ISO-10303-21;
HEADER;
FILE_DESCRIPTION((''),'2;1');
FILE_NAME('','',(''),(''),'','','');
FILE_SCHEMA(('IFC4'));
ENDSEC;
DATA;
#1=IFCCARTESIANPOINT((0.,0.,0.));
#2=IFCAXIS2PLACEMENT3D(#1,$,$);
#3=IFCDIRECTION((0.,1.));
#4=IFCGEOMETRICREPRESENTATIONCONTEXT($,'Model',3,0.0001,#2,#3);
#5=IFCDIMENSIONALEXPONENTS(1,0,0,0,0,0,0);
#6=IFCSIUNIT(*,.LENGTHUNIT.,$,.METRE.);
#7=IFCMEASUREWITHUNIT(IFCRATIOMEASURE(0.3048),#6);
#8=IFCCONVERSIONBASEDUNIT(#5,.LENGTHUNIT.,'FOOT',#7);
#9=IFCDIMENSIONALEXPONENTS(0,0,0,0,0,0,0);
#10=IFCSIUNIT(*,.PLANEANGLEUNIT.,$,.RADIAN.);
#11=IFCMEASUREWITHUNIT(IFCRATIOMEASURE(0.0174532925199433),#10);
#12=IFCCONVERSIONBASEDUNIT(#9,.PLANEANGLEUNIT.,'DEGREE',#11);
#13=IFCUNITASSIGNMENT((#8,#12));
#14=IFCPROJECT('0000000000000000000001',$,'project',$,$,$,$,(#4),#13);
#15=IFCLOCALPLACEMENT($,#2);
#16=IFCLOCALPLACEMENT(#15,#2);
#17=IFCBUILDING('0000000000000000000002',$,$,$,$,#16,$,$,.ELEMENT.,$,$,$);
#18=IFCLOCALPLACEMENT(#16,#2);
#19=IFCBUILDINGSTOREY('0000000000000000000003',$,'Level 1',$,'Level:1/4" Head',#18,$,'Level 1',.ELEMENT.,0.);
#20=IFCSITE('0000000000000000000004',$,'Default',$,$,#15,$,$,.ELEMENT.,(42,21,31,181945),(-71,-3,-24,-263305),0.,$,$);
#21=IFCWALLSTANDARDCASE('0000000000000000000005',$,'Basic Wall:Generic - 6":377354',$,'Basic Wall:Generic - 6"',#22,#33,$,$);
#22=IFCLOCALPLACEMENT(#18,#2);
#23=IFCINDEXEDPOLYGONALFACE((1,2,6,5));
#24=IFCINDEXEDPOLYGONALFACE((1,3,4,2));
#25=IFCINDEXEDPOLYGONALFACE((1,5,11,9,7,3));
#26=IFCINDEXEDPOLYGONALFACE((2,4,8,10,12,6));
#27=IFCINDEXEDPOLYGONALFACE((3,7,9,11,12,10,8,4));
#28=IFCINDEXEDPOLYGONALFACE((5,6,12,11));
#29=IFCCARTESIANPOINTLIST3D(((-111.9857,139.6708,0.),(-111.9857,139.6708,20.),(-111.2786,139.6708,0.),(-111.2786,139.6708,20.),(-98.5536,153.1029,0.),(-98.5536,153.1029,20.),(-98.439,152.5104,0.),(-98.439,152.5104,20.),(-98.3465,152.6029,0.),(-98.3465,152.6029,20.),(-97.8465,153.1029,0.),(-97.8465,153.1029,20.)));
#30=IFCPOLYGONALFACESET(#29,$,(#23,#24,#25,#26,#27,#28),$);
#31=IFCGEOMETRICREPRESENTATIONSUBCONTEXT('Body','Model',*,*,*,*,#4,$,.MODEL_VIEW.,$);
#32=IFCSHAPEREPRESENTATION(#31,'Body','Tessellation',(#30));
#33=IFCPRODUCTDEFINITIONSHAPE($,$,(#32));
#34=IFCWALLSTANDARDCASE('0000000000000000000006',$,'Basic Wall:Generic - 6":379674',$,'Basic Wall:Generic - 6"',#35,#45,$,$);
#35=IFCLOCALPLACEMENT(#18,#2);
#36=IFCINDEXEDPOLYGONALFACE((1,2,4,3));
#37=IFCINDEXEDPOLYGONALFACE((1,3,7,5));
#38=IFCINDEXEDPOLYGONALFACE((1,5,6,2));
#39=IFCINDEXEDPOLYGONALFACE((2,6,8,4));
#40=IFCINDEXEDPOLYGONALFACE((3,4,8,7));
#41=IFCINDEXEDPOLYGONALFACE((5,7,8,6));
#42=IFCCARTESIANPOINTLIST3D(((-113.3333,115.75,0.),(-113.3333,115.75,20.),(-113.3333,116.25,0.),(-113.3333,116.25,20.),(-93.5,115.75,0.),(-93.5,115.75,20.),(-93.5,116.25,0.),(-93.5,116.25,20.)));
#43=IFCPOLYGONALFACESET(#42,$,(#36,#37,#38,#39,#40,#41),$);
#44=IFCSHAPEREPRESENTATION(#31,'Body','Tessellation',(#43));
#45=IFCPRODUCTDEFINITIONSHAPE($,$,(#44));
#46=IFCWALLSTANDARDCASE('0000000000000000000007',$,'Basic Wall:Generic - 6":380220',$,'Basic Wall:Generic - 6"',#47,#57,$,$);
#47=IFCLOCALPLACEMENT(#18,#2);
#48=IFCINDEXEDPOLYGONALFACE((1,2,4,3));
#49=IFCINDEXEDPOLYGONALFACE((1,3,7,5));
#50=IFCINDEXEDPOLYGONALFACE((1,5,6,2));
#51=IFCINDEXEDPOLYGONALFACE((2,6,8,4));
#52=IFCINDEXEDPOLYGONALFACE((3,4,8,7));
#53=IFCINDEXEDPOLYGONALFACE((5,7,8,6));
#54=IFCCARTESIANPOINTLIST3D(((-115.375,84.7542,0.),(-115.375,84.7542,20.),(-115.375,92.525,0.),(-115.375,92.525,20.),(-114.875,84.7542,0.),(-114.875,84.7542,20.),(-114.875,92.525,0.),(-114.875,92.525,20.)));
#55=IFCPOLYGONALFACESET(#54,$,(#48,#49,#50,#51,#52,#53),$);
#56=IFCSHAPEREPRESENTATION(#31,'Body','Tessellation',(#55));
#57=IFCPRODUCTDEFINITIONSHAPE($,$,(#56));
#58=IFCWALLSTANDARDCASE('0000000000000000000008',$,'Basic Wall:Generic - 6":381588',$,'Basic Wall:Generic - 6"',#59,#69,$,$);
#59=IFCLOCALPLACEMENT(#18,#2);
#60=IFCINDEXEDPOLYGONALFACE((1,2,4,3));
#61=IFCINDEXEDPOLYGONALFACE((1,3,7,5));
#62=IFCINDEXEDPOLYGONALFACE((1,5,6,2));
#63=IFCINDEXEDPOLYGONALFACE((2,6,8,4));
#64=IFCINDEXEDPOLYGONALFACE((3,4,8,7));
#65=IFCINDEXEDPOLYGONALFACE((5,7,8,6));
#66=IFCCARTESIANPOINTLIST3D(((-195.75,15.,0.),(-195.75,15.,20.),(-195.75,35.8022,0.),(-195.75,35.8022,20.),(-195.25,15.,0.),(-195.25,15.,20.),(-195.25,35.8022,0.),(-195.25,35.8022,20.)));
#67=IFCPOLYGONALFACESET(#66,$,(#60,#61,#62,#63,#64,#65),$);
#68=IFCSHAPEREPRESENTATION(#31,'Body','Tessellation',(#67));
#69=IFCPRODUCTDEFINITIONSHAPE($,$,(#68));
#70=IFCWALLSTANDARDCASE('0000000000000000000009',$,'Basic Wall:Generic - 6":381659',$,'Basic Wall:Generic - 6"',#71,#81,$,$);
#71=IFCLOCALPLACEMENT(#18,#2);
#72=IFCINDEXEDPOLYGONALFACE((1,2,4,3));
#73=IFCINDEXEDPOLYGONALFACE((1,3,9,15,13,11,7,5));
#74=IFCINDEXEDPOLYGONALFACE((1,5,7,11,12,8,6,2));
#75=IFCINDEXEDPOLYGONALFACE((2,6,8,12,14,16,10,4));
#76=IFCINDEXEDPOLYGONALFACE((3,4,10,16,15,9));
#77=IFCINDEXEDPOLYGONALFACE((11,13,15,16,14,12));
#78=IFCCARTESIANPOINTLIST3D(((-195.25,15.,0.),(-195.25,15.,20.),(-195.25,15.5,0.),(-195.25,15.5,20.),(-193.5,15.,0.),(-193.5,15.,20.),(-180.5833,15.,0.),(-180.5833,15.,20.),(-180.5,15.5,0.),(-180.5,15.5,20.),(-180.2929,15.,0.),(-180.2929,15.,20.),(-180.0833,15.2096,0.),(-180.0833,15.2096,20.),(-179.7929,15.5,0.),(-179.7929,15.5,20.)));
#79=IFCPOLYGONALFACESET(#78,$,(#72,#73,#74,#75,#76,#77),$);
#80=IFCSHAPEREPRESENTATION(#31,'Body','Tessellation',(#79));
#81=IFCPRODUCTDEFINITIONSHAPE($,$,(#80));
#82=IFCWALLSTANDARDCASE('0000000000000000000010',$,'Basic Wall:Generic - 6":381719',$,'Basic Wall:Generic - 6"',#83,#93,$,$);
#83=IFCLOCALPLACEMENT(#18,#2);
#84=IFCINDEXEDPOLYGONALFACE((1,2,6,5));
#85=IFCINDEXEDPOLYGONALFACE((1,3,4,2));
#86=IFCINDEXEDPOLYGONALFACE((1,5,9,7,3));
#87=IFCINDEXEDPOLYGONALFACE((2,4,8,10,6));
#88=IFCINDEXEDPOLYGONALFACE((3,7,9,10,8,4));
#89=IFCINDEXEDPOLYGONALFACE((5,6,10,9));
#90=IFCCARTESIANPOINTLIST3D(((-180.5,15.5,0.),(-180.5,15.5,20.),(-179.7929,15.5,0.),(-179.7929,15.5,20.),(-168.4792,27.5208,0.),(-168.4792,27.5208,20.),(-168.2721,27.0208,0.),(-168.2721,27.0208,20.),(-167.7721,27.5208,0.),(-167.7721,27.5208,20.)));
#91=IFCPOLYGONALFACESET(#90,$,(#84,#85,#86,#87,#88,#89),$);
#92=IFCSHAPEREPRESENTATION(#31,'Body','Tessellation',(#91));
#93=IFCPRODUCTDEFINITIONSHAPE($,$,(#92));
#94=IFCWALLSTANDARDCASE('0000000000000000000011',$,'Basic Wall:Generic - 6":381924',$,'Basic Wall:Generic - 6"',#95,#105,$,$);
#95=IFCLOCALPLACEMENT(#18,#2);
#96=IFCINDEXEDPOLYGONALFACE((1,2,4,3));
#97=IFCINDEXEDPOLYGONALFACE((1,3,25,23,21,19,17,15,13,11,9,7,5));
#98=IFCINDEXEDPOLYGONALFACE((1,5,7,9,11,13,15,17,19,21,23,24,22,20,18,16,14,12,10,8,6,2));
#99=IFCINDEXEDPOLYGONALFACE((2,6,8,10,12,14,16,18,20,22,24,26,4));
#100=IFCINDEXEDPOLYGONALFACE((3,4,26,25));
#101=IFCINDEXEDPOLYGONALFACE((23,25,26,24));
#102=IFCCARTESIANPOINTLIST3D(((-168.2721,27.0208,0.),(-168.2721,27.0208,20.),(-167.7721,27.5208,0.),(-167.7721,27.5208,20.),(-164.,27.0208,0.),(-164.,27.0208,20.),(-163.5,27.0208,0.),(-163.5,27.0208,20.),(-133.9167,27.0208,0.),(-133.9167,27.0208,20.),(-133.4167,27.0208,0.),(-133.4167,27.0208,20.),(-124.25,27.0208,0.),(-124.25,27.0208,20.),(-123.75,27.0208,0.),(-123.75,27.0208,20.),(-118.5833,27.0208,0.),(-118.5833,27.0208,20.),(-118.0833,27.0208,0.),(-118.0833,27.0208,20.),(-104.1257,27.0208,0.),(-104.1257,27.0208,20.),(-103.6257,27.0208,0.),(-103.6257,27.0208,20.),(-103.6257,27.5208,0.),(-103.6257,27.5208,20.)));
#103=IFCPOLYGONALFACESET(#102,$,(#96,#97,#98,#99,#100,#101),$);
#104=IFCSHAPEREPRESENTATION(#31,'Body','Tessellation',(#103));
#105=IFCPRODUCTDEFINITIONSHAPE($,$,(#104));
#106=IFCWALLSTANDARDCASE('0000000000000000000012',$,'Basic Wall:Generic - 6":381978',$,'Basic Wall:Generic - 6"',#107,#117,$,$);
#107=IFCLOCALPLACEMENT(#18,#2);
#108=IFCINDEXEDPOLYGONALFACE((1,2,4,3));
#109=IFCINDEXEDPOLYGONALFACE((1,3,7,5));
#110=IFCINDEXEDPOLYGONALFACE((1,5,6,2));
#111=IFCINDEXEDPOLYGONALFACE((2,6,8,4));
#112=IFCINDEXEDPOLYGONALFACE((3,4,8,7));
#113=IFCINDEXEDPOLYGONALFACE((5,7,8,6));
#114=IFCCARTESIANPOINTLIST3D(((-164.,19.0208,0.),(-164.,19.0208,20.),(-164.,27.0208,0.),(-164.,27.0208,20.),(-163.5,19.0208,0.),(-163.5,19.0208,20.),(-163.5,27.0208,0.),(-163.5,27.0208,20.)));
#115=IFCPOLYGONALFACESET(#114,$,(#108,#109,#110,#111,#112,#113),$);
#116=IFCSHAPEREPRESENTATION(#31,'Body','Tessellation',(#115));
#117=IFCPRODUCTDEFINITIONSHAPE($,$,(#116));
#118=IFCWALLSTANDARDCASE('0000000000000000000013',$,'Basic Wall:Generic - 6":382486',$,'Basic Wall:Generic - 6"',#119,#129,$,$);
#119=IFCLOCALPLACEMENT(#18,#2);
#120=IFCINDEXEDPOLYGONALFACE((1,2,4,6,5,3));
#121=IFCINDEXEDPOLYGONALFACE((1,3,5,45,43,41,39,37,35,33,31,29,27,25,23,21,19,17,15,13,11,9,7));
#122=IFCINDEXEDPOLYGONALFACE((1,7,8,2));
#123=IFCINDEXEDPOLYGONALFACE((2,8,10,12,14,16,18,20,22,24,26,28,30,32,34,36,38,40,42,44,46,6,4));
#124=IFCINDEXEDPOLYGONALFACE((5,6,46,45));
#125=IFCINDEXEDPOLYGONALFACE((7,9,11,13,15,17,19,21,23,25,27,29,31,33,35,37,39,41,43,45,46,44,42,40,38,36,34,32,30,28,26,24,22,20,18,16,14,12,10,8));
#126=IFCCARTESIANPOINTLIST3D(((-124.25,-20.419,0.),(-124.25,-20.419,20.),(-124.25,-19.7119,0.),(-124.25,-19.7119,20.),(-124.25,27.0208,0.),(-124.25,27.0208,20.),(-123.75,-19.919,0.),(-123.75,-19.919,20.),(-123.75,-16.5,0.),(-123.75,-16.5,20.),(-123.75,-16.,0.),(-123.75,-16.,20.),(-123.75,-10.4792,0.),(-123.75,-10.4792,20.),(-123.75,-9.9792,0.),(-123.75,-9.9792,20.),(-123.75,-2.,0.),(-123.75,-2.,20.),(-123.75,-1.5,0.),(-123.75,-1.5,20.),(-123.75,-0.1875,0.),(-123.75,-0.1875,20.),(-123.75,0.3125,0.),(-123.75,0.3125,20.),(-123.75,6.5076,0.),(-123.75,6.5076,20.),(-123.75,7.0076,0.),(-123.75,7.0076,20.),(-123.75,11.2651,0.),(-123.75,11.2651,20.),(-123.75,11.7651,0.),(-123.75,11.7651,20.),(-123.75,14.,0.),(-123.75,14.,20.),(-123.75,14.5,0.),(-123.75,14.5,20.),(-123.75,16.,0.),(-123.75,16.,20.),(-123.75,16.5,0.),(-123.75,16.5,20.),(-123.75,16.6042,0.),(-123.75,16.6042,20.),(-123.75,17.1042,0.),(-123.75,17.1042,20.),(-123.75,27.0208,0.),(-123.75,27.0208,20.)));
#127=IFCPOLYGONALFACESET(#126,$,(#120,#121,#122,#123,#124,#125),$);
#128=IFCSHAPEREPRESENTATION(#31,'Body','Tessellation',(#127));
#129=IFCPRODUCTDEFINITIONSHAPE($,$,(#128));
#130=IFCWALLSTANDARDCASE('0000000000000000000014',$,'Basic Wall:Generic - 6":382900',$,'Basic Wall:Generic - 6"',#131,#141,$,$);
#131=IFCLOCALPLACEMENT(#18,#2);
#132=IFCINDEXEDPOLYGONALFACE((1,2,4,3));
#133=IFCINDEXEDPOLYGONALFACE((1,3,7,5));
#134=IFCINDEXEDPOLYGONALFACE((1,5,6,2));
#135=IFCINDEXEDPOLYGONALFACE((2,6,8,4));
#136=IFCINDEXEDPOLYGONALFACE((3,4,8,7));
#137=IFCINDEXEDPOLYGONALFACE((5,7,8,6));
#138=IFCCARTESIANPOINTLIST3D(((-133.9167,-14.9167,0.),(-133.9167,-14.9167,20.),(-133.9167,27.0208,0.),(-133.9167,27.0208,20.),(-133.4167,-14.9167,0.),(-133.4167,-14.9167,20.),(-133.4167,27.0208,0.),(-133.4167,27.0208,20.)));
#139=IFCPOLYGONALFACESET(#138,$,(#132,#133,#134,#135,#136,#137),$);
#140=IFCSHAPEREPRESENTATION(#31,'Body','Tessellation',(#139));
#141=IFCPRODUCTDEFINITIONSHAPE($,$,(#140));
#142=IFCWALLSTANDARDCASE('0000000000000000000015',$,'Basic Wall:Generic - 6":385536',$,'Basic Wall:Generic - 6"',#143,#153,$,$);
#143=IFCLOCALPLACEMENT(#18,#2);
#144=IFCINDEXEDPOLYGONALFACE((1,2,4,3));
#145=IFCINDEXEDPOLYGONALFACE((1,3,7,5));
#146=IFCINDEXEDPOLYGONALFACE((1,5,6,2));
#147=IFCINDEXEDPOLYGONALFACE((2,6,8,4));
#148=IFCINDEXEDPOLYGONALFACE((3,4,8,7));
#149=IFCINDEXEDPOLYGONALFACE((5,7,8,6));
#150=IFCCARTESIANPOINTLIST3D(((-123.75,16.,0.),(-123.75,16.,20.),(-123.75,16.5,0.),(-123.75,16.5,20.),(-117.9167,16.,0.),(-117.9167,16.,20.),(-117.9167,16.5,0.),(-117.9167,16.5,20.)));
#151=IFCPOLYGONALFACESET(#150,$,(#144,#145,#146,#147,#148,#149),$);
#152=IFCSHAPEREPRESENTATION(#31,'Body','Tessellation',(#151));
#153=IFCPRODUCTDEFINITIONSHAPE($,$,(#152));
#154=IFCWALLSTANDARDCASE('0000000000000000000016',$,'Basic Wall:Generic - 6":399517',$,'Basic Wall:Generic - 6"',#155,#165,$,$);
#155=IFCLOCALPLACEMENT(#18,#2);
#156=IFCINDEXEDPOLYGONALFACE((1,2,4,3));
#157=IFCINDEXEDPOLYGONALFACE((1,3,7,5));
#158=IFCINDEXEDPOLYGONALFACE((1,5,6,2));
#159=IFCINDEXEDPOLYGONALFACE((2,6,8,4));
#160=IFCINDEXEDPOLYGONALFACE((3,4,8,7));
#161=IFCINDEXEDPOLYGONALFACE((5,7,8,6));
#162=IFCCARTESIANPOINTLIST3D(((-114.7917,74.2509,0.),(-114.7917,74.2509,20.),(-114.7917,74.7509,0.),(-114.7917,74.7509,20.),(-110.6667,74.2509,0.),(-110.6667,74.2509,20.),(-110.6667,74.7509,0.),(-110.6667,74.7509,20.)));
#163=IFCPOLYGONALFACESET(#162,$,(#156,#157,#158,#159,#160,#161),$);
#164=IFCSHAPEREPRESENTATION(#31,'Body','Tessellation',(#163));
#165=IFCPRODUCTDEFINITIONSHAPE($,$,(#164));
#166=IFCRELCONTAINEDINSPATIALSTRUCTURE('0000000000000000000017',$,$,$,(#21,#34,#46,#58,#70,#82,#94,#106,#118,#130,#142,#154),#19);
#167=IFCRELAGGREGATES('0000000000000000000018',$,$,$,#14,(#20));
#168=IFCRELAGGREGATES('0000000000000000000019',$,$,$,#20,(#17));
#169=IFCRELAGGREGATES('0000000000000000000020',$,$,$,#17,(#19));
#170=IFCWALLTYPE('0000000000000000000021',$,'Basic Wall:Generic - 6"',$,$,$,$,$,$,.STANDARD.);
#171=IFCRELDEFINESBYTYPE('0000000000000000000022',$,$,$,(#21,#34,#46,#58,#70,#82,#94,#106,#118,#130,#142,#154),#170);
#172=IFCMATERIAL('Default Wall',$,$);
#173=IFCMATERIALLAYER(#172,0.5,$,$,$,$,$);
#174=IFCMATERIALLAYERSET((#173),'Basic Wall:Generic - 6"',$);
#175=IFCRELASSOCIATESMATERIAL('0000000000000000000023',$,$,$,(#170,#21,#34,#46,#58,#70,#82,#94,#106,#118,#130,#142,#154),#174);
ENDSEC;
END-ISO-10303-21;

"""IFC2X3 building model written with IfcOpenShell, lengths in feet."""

from ifc_helpers import new_model, entity, si_unit, converted_unit, direction, frame, frame_2d, origin, place, context, subcontext, project, spatial, polyline, rectangle, outline, extrude, material, layer, layer_set, layer_usage, type_object, element, save


model = new_model("IFC2X3")

# Units and contexts
model_context = context("Model", 3, precision=0.0001, world=origin(), true_north=direction((0.0, 1.0)))
body_context = subcontext(model_context, "Body", "Model", "MODEL_VIEW")
ifc_project = project(units=[converted_unit("LENGTHUNIT", "FOOT", entity("IfcRatioMeasure", 0.3048), si_unit("LENGTHUNIT", "METRE"), dimensions=[1, 0, 0, 0, 0, 0, 0]), converted_unit("PLANEANGLEUNIT", "DEGREE", entity("IfcRatioMeasure", 0.0174532925199433), si_unit("PLANEANGLEUNIT", "RADIAN"), dimensions=[0, 0, 0, 0, 0, 0, 0])], contexts=[model_context])

# Site, building, storey
site_placement = place(None, origin())
site = spatial("IfcSite", under=ifc_project, at=site_placement, Name="Default", CompositionType="ELEMENT", RefLatitude=(42, 21, 31, 181945), RefLongitude=(-71, -3, -24, -263305), RefElevation=0.0)
building_placement = place(site_placement, origin())
building = spatial("IfcBuilding", under=site, at=building_placement, CompositionType="ELEMENT")
storey_placement = place(building_placement, origin())
storey = spatial("IfcBuildingStorey", under=building, at=storey_placement, Name="Level 1", ObjectType="Level:1/4\" Head", LongName="Level 1", CompositionType="ELEMENT", Elevation=0.0)

# Walls
ifc_material = material(Name="Default Wall")
ifc_layer_1 = layer(ifc_material, 0.5)
ifc_layer_set_1 = layer_set([ifc_layer_1], Name="Basic Wall:Generic - 6\"")
wall_type_1 = type_object("IfcWallType", Name="Basic Wall:Generic - 6\"", PredefinedType="STANDARD", material=ifc_layer_set_1)
ifc_layer_usage_1 = layer_usage(ifc_layer_set_1, "AXIS2", "NEGATIVE", 0.25)
wall_1_placement = place(storey_placement, frame((-111.8089, 139.4941, 0.0), z_axis=(0.0, 0.0, 1.0), x_axis=(0.707107, 0.707107, 0.0)))
element("IfcWallStandardCase", 1, at=wall_1_placement, inside=storey, type_object=wall_type_1, material=ifc_layer_usage_1, Name="Basic Wall:Generic - 6\":377354", ObjectType="Basic Wall:Generic - 6\"", context=body_context, shape_type="SweptSolid", body=[
    extrude(outline(polyline([(19.4959, -0.25), (18.9959, 0.25), (0.0, 0.25), (0.5, -0.25), (18.6579, -0.25), (18.7888, -0.25), (19.4959, -0.25)])), origin(), (0.0, 0.0, 1.0), 20.0),
])
ifc_layer_usage_2 = layer_usage(ifc_layer_set_1, "AXIS2", "NEGATIVE", 0.25)
wall_2_placement = place(storey_placement, frame((-113.3333, 116.0, 0.0)))
element("IfcWallStandardCase", 2, at=wall_2_placement, inside=storey, type_object=wall_type_1, material=ifc_layer_usage_2, Name="Basic Wall:Generic - 6\":379674", ObjectType="Basic Wall:Generic - 6\"", context=body_context, shape_type="SweptSolid", body=[
    extrude(rectangle(XDim=19.8333, YDim=0.5, at=frame_2d((9.9167, 0.0), x_axis=(-1.0, 0.0))), origin(), (0.0, 0.0, 1.0), 20.0),
])
ifc_layer_usage_3 = layer_usage(ifc_layer_set_1, "AXIS2", "NEGATIVE", 0.25)
wall_3_placement = place(storey_placement, frame((-115.125, 84.7542, 0.0), z_axis=(0.0, 0.0, 1.0), x_axis=(0.0, 1.0, 0.0)))
element("IfcWallStandardCase", 3, at=wall_3_placement, inside=storey, type_object=wall_type_1, material=ifc_layer_usage_3, Name="Basic Wall:Generic - 6\":380220", ObjectType="Basic Wall:Generic - 6\"", context=body_context, shape_type="SweptSolid", body=[
    extrude(rectangle(XDim=7.7708, YDim=0.5, at=frame_2d((3.8854, 0.0), x_axis=(-1.0, 0.0))), origin(), (0.0, 0.0, 1.0), 20.0),
])
ifc_layer_usage_4 = layer_usage(ifc_layer_set_1, "AXIS2", "NEGATIVE", 0.25)
wall_4_placement = place(storey_placement, frame((-195.5, 35.8022, 0.0), z_axis=(0.0, 0.0, 1.0), x_axis=(0.0, -1.0, 0.0)))
element("IfcWallStandardCase", 4, at=wall_4_placement, inside=storey, type_object=wall_type_1, material=ifc_layer_usage_4, Name="Basic Wall:Generic - 6\":381588", ObjectType="Basic Wall:Generic - 6\"", context=body_context, shape_type="SweptSolid", body=[
    extrude(rectangle(XDim=20.8022, YDim=0.5, at=frame_2d((10.4011, 0.0), x_axis=(-1.0, 0.0))), origin(), (0.0, 0.0, 1.0), 20.0),
])
ifc_layer_usage_5 = layer_usage(ifc_layer_set_1, "AXIS2", "NEGATIVE", 0.25)
wall_5_placement = place(storey_placement, frame((-195.25, 15.25, 0.0)))
element("IfcWallStandardCase", 5, at=wall_5_placement, inside=storey, type_object=wall_type_1, material=ifc_layer_usage_5, Name="Basic Wall:Generic - 6\":381659", ObjectType="Basic Wall:Generic - 6\"", context=body_context, shape_type="SweptSolid", body=[
    extrude(outline(polyline([(14.9571, -0.25), (15.1667, -0.0404), (15.4571, 0.25), (14.75, 0.25), (0.0, 0.25), (0.0, -0.25), (1.75, -0.25), (14.6667, -0.25), (14.9571, -0.25)])), origin(), (0.0, 0.0, 1.0), 20.0),
])
ifc_layer_usage_6 = layer_usage(ifc_layer_set_1, "AXIS2", "NEGATIVE", 0.25)
wall_6_placement = place(storey_placement, frame((-180.3233, 15.3232, 0.0), z_axis=(0.0, 0.0, 1.0), x_axis=(0.707107, 0.707107, 0.0)))
element("IfcWallStandardCase", 6, at=wall_6_placement, inside=storey, type_object=wall_type_1, material=ifc_layer_usage_6, Name="Basic Wall:Generic - 6\":381719", ObjectType="Basic Wall:Generic - 6\"", context=body_context, shape_type="SweptSolid", body=[
    extrude(outline(polyline([(17.5, -0.25), (17.0, 0.25), (0.0, 0.25), (0.5, -0.25), (16.7929, -0.25), (17.5, -0.25)])), origin(), (0.0, 0.0, 1.0), 20.0),
])
ifc_layer_usage_7 = layer_usage(ifc_layer_set_1, "AXIS2", "NEGATIVE", 0.25)
wall_7_placement = place(storey_placement, frame((-168.2721, 27.2708, 0.0)))
element("IfcWallStandardCase", 7, at=wall_7_placement, inside=storey, type_object=wall_type_1, material=ifc_layer_usage_7, Name="Basic Wall:Generic - 6\":381924", ObjectType="Basic Wall:Generic - 6\"", context=body_context, shape_type="SweptSolid", body=[
    extrude(outline(polyline([(64.6464, -0.25), (64.6464, 0.25), (0.5, 0.25), (0.0, -0.25), (4.2721, -0.25), (4.7721, -0.25), (34.3554, -0.25), (34.8554, -0.25), (44.0221, -0.25), (44.5221, -0.25), (49.6888, -0.25), (50.1888, -0.25), (64.1464, -0.25), (64.6464, -0.25)])), origin(), (0.0, 0.0, 1.0), 20.0),
])
ifc_layer_usage_8 = layer_usage(ifc_layer_set_1, "AXIS2", "NEGATIVE", 0.25)
wall_8_placement = place(storey_placement, frame((-163.75, 27.0208, 0.0), z_axis=(0.0, 0.0, 1.0), x_axis=(0.0, -1.0, 0.0)))
element("IfcWallStandardCase", 8, at=wall_8_placement, inside=storey, type_object=wall_type_1, material=ifc_layer_usage_8, Name="Basic Wall:Generic - 6\":381978", ObjectType="Basic Wall:Generic - 6\"", context=body_context, shape_type="SweptSolid", body=[
    extrude(rectangle(XDim=8.0, YDim=0.5, at=frame_2d((4.0, 0.0), x_axis=(-1.0, 0.0))), origin(), (0.0, 0.0, 1.0), 20.0),
])
ifc_layer_usage_9 = layer_usage(ifc_layer_set_1, "AXIS2", "NEGATIVE", 0.25)
wall_9_placement = place(storey_placement, frame((-124.0, 27.0208, 0.0), z_axis=(0.0, 0.0, 1.0), x_axis=(0.0, -1.0, 0.0)))
element("IfcWallStandardCase", 9, at=wall_9_placement, inside=storey, type_object=wall_type_1, material=ifc_layer_usage_9, Name="Basic Wall:Generic - 6\":382486", ObjectType="Basic Wall:Generic - 6\"", context=body_context, shape_type="SweptSolid", body=[
    extrude(outline(polyline([(47.4398, -0.25), (46.9398, 0.25), (43.5208, 0.25), (43.0208, 0.25), (37.5, 0.25), (37.0, 0.25), (29.0208, 0.25), (28.5208, 0.25), (27.2083, 0.25), (26.7083, 0.25), (20.5132, 0.25), (20.0132, 0.25), (15.7558, 0.25), (15.2558, 0.25), (13.0208, 0.25), (12.5208, 0.25), (11.0208, 0.25), (10.5208, 0.25), (10.4167, 0.25), (9.9167, 0.25), (0.0, 0.25), (0.0, -0.25), (46.7327, -0.25), (47.4398, -0.25)])), origin(), (0.0, 0.0, 1.0), 20.0),
])
ifc_layer_usage_10 = layer_usage(ifc_layer_set_1, "AXIS2", "NEGATIVE", 0.25)
wall_10_placement = place(storey_placement, frame((-133.6667, 27.0208, 0.0), z_axis=(0.0, 0.0, 1.0), x_axis=(0.0, -1.0, 0.0)))
element("IfcWallStandardCase", 10, at=wall_10_placement, inside=storey, type_object=wall_type_1, material=ifc_layer_usage_10, Name="Basic Wall:Generic - 6\":382900", ObjectType="Basic Wall:Generic - 6\"", context=body_context, shape_type="SweptSolid", body=[
    extrude(rectangle(XDim=41.9375, YDim=0.5, at=frame_2d((20.9687, 0.0), x_axis=(-1.0, 0.0))), origin(), (0.0, 0.0, 1.0), 20.0),
])
ifc_layer_usage_11 = layer_usage(ifc_layer_set_1, "AXIS2", "NEGATIVE", 0.25)
wall_11_placement = place(storey_placement, frame((-117.9167, 16.25, 0.0), z_axis=(0.0, 0.0, 1.0), x_axis=(-1.0, 0.0, 0.0)))
element("IfcWallStandardCase", 11, at=wall_11_placement, inside=storey, type_object=wall_type_1, material=ifc_layer_usage_11, Name="Basic Wall:Generic - 6\":385536", ObjectType="Basic Wall:Generic - 6\"", context=body_context, shape_type="SweptSolid", body=[
    extrude(rectangle(XDim=5.8333, YDim=0.5, at=frame_2d((2.9167, 0.0), x_axis=(-1.0, 0.0))), origin(), (0.0, 0.0, 1.0), 20.0),
])
ifc_layer_usage_12 = layer_usage(ifc_layer_set_1, "AXIS2", "NEGATIVE", 0.25)
wall_12_placement = place(storey_placement, frame((-114.7917, 74.5009, 0.0)))
element("IfcWallStandardCase", 12, at=wall_12_placement, inside=storey, type_object=wall_type_1, material=ifc_layer_usage_12, Name="Basic Wall:Generic - 6\":399517", ObjectType="Basic Wall:Generic - 6\"", context=body_context, shape_type="SweptSolid", body=[
    extrude(rectangle(XDim=4.125, YDim=0.5, at=frame_2d((2.0625, 0.0), x_axis=(-1.0, 0.0))), origin(), (0.0, 0.0, 1.0), 20.0),
])

save(model, "model.ifc")
